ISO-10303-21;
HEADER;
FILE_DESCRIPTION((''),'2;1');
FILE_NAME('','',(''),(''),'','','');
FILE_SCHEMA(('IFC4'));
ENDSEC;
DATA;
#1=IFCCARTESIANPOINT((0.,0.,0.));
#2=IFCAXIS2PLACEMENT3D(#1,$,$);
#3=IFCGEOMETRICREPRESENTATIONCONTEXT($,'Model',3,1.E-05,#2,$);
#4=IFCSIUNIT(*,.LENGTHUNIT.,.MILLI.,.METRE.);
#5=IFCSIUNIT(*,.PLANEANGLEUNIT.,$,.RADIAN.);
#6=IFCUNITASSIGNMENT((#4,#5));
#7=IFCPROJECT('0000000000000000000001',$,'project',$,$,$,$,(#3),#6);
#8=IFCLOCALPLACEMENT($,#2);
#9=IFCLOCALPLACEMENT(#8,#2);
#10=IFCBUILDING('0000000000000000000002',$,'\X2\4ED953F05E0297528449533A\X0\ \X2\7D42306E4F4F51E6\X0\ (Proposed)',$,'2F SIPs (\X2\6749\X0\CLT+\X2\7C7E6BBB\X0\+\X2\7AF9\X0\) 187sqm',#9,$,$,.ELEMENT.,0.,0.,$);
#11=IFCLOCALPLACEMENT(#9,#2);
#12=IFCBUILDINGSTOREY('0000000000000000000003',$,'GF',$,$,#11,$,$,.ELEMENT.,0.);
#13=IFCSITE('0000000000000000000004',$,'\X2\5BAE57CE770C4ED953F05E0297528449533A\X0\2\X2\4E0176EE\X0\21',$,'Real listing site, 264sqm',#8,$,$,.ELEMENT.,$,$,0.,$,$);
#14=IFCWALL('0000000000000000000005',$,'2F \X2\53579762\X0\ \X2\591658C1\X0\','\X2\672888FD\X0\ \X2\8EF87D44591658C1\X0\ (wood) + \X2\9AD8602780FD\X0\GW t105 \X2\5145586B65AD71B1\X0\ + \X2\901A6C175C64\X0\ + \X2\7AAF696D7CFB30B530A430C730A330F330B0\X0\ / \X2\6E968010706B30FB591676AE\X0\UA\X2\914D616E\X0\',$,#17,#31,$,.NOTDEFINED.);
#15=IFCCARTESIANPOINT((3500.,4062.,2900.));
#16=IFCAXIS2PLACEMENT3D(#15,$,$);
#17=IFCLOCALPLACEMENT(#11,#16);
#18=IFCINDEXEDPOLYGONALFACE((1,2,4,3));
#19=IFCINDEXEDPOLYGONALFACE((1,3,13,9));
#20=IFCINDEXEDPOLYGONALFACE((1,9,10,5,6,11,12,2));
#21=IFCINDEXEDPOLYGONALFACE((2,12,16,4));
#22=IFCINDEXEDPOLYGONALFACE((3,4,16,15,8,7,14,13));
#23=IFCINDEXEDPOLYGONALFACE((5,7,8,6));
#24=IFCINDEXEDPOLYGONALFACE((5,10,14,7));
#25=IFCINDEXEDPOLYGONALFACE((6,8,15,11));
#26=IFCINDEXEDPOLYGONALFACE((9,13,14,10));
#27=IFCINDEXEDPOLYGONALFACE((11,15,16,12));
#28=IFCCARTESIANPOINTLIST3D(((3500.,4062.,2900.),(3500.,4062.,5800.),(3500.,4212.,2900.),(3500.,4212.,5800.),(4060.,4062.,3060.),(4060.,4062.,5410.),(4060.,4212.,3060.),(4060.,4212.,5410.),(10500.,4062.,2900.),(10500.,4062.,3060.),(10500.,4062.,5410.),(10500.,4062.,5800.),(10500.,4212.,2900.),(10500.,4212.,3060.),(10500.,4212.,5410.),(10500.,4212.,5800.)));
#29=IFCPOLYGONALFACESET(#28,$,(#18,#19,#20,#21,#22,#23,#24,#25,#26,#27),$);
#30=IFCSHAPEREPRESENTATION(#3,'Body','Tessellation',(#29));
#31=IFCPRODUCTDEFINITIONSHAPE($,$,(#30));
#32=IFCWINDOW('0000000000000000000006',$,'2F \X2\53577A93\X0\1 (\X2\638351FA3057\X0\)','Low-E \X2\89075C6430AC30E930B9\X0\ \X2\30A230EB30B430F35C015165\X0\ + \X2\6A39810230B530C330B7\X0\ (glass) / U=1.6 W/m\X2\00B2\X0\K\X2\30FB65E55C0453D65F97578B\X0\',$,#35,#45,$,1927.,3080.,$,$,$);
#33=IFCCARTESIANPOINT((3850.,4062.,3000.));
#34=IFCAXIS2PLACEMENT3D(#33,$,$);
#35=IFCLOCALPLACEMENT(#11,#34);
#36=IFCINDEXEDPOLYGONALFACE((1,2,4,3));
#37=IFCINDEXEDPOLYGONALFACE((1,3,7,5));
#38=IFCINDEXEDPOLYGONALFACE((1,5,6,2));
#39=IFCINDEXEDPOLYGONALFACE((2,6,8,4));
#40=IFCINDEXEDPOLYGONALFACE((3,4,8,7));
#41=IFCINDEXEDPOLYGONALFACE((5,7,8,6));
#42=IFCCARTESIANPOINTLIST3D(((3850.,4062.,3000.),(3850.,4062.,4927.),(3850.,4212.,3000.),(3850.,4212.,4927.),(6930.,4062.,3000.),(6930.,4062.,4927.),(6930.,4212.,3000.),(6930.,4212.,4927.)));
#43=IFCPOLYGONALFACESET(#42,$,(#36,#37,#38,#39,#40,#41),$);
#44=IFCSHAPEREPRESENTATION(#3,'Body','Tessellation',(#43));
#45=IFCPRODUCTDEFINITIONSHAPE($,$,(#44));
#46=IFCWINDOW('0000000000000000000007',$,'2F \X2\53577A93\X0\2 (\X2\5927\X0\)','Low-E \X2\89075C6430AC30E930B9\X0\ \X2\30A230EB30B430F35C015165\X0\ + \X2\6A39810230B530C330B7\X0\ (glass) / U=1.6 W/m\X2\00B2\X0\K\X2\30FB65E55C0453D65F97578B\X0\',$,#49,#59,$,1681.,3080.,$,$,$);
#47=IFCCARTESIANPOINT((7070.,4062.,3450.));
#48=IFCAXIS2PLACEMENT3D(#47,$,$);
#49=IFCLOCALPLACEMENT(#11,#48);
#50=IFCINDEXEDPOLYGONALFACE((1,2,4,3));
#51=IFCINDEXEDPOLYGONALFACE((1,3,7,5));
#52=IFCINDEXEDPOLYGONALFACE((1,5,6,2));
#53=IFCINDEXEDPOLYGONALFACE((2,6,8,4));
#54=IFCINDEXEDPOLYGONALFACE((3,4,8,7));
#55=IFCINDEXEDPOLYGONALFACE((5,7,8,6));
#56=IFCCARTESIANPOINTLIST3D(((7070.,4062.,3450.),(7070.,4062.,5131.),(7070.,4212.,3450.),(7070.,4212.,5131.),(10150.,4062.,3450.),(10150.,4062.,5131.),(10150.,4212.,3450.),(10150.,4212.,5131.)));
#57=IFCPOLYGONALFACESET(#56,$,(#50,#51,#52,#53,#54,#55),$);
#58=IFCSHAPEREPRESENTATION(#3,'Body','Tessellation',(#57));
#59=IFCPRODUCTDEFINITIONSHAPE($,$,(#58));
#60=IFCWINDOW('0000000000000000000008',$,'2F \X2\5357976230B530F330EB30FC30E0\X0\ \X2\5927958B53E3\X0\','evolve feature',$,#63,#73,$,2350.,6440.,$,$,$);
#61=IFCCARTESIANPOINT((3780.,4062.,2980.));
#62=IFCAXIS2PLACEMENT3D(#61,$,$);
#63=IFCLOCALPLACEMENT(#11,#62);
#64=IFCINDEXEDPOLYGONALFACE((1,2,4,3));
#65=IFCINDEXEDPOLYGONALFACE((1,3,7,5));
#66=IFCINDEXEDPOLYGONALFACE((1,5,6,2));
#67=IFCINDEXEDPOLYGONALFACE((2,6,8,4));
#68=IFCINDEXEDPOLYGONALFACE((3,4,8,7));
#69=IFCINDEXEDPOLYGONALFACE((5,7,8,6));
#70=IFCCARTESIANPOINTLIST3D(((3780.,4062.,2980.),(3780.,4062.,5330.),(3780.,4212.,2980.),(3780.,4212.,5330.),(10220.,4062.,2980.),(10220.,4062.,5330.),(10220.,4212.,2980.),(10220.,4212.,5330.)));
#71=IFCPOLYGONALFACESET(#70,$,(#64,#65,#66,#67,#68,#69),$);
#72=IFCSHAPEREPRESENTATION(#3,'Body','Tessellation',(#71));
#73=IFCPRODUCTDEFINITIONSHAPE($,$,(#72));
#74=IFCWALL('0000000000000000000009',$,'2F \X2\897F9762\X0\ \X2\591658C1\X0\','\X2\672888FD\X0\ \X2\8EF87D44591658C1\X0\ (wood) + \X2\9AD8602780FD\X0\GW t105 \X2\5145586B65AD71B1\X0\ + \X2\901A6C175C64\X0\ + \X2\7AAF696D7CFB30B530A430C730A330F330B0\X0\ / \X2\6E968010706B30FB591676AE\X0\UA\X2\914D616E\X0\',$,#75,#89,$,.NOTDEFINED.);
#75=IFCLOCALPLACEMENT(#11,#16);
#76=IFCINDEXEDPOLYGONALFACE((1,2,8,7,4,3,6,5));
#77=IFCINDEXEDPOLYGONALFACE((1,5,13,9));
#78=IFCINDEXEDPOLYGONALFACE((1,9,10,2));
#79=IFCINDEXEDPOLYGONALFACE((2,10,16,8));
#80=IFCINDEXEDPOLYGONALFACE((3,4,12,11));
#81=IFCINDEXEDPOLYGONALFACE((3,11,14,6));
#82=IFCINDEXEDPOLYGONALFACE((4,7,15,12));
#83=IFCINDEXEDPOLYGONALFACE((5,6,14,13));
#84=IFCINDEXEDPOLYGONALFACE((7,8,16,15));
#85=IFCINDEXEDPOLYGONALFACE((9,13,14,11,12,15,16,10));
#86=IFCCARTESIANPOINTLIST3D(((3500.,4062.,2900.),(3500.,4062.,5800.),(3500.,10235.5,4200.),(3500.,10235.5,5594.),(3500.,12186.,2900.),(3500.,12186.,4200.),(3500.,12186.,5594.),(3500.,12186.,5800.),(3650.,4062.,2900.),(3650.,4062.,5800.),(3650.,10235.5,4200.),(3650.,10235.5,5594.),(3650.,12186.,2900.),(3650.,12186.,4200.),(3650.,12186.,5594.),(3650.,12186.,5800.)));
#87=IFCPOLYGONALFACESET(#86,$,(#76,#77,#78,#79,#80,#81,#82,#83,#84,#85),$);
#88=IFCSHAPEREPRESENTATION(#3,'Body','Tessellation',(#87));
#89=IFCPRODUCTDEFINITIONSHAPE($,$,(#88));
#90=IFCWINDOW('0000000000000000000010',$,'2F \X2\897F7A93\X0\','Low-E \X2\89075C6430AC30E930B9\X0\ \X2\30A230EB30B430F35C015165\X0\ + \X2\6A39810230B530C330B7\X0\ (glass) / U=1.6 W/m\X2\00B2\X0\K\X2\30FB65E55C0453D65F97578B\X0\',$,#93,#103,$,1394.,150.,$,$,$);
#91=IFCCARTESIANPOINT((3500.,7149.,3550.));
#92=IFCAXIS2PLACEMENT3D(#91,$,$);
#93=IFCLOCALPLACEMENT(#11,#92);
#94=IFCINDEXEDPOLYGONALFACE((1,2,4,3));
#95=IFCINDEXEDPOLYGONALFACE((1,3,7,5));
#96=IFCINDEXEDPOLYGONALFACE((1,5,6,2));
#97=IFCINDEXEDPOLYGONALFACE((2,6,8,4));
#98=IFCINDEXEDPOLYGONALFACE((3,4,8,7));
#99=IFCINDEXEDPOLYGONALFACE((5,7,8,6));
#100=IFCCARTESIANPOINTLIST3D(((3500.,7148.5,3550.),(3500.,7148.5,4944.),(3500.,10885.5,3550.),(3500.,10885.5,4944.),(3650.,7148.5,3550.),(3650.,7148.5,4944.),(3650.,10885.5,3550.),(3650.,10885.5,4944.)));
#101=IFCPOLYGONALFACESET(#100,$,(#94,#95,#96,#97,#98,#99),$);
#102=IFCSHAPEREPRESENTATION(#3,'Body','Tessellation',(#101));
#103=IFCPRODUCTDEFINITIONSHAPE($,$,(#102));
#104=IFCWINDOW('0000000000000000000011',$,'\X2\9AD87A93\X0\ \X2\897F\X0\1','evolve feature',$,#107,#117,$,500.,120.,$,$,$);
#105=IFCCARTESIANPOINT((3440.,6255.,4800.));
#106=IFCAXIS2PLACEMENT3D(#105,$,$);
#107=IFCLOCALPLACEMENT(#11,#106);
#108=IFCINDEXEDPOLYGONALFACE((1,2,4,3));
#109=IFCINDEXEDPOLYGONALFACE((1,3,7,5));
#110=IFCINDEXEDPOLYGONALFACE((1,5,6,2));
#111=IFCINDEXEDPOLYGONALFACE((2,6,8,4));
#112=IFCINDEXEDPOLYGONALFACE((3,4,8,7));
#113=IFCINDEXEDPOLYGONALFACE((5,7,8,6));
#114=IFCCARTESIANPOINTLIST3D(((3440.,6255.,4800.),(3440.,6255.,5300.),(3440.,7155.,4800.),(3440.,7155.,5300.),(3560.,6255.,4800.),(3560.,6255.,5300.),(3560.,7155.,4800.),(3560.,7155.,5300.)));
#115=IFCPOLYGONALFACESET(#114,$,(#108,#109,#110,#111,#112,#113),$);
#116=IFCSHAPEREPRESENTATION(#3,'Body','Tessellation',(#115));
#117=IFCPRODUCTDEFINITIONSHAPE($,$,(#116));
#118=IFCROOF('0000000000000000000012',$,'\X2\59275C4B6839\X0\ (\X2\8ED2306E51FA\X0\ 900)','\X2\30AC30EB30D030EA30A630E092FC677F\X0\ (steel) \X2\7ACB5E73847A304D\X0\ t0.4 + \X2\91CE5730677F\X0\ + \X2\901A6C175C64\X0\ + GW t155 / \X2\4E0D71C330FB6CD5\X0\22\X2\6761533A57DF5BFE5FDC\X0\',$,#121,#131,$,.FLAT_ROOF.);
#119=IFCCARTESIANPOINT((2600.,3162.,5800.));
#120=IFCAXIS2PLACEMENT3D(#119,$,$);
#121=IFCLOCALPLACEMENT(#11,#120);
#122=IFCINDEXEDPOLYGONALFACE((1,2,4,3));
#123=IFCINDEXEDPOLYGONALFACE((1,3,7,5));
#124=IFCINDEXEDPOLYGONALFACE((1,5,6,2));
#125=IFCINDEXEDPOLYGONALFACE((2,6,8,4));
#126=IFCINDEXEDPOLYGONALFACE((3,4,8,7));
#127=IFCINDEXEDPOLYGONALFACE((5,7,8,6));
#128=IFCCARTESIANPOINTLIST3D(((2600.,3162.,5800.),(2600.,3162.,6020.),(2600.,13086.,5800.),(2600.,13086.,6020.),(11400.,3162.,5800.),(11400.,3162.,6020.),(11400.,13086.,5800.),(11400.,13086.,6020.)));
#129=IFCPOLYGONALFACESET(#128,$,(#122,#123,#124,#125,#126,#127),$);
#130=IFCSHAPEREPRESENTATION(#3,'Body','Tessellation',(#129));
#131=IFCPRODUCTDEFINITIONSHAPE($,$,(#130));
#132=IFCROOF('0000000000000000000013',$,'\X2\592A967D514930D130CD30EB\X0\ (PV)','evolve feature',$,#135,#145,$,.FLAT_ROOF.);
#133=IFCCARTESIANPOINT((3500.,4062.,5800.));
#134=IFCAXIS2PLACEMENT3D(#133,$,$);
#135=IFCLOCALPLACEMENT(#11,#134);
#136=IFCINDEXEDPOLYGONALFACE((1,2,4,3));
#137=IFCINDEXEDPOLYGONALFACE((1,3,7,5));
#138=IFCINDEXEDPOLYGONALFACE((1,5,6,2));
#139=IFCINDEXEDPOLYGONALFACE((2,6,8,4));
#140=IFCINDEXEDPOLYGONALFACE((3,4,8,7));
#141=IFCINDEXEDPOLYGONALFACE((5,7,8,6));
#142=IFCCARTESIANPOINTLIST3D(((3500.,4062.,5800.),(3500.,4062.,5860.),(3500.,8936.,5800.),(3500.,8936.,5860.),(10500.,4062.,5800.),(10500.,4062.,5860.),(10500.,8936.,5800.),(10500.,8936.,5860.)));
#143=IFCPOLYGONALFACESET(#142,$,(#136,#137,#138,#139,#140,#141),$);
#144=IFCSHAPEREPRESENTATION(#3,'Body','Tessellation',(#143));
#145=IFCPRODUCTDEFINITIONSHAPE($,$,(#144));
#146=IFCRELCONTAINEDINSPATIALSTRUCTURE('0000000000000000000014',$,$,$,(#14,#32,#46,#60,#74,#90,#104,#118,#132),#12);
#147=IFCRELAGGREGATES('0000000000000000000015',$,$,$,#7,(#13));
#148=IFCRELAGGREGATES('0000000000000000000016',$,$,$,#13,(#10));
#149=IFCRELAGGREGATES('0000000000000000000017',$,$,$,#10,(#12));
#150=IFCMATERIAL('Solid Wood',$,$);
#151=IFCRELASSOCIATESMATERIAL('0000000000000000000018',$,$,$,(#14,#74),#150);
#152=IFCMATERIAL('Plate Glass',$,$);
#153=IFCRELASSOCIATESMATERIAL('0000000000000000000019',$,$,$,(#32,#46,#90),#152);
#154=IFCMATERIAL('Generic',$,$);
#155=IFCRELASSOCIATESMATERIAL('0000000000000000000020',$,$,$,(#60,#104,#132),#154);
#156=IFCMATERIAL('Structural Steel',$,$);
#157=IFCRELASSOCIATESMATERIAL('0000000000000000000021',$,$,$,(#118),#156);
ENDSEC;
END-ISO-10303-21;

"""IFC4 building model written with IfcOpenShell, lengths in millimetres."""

from ifc_helpers import new_model, si_unit, frame, frame_2d, origin, place, context, project, spatial, rectangle, extrude, material, element, fill, save


model = new_model("IFC4")

# Units and contexts
model_context = context("Model", 3, precision=1e-05, world=origin())
ifc_project = project(units=[si_unit("LENGTHUNIT", "METRE", prefix="MILLI"), si_unit("PLANEANGLEUNIT", "RADIAN")], contexts=[model_context])

# Site, building, storey
site_placement = place(None, origin())
site = spatial("IfcSite", under=ifc_project, at=site_placement, Name="宮城県仙台市青葉区2丁目21", ObjectType="Real listing site, 264sqm", CompositionType="ELEMENT", RefElevation=0.0)
building_placement = place(site_placement, origin())
building = spatial("IfcBuilding", under=site, at=building_placement, Name="仙台市青葉区 終の住処 (Proposed)", ObjectType="2F SIPs (杉CLT+籾殻+竹) 187sqm", CompositionType="ELEMENT", ElevationOfRefHeight=0.0, ElevationOfTerrain=0.0)
storey_placement = place(building_placement, origin())
storey = spatial("IfcBuildingStorey", under=building, at=storey_placement, Name="GF", CompositionType="ELEMENT", Elevation=0.0)

# Shared definitions
ifc_material_1 = material(Name="Solid Wood")
ifc_material_2 = material(Name="Generic")

# Shared definitions
ifc_material_3 = material(Name="Plate Glass")

# Walls, openings, windows
wall_1_placement = place(storey_placement, frame((3500.0, 4062.0, 2900.0)))
wall_1 = element("IfcWall", 1, at=wall_1_placement, inside=storey, material=ifc_material_1, Name="2F 南面 外壁", Description="木製 軸組外壁 (wood) + 高性能GW t105 充填断熱 + 通気層 + 窯業系サイディング / 準耐火・外皮UA配慮", PredefinedType="NOTDEFINED", context=model_context, shape_type="SweptSolid", body=[
    extrude(rectangle(XDim=7000.0, YDim=150.0, at=frame_2d((3500.0, 75.0))), frame((3500.0, 4062.0, 2900.0)), (0.0, 0.0, 1.0), 2900.0),
])
opening_1_placement = place(storey_placement, frame((3850.0, 4062.0, 3000.0)))
opening_1 = element("IfcOpeningElement", 2, at=opening_1_placement, cuts=wall_1, PredefinedType="NOTDEFINED", context=model_context, shape_type="SweptSolid", body=[
    extrude(rectangle(XDim=3080.0, YDim=150.0, at=frame_2d((1540.0, 75.0))), frame((3850.0, 4062.0, 3000.0)), (0.0, 0.0, 1.0), 1927.0),
])
opening_2_placement = place(storey_placement, frame((7070.0, 4062.0, 3450.0)))
opening_2 = element("IfcOpeningElement", 3, at=opening_2_placement, cuts=wall_1, PredefinedType="NOTDEFINED", context=model_context, shape_type="SweptSolid", body=[
    extrude(rectangle(XDim=3080.0, YDim=150.0, at=frame_2d((1540.0, 75.0))), frame((7070.0, 4062.0, 3450.0)), (0.0, 0.0, 1.0), 1681.0),
])
opening_3_placement = place(storey_placement, frame((3780.0, 4062.0, 2980.0)))
opening_3 = element("IfcOpeningElement", 4, at=opening_3_placement, cuts=wall_1, PredefinedType="NOTDEFINED", context=model_context, shape_type="SweptSolid", body=[
    extrude(rectangle(XDim=6440.0, YDim=150.0, at=frame_2d((3220.0, 75.0))), frame((3780.0, 4062.0, 2980.0)), (0.0, 0.0, 1.0), 2350.0),
])
window_1_placement = place(storey_placement, frame((3850.0, 4062.0, 3000.0)))
window_1 = element("IfcWindow", 5, at=window_1_placement, inside=storey, material=ifc_material_3, Name="2F 南窓1 (掃出し)", Description="Low-E 複層ガラス アルゴン封入 + 樹脂サッシ (glass) / U=1.6 W/m²K・日射取得型", OverallHeight=1927.0, OverallWidth=3080.0, context=model_context, shape_type="SweptSolid", body=[
    extrude(rectangle(XDim=3080.0, YDim=150.0, at=frame_2d((1540.0, 75.0))), frame((3850.0, 4062.0, 3000.0)), (0.0, 0.0, 1.0), 1927.0),
])
fill(opening_1, window_1)
window_2_placement = place(storey_placement, frame((7070.0, 4062.0, 3450.0)))
window_2 = element("IfcWindow", 6, at=window_2_placement, inside=storey, material=ifc_material_3, Name="2F 南窓2 (大)", Description="Low-E 複層ガラス アルゴン封入 + 樹脂サッシ (glass) / U=1.6 W/m²K・日射取得型", OverallHeight=1681.0, OverallWidth=3080.0, context=model_context, shape_type="SweptSolid", body=[
    extrude(rectangle(XDim=3080.0, YDim=150.0, at=frame_2d((1540.0, 75.0))), frame((7070.0, 4062.0, 3450.0)), (0.0, 0.0, 1.0), 1681.0),
])
fill(opening_2, window_2)
window_3_placement = place(storey_placement, frame((3780.0, 4062.0, 2980.0)))
window_3 = element("IfcWindow", 7, at=window_3_placement, inside=storey, material=ifc_material_2, Name="2F 南面サンルーム 大開口", Description="evolve feature", OverallHeight=2350.0, OverallWidth=6440.0, context=model_context, shape_type="SweptSolid", body=[
    extrude(rectangle(XDim=6440.0, YDim=150.0, at=frame_2d((3220.0, 75.0))), frame((3780.0, 4062.0, 2980.0)), (0.0, 0.0, 1.0), 2350.0),
])
fill(opening_3, window_3)
wall_2_placement = place(storey_placement, frame((3500.0, 4062.0, 2900.0)))
wall_2 = element("IfcWall", 8, at=wall_2_placement, inside=storey, material=ifc_material_1, Name="2F 西面 外壁", Description="木製 軸組外壁 (wood) + 高性能GW t105 充填断熱 + 通気層 + 窯業系サイディング / 準耐火・外皮UA配慮", PredefinedType="NOTDEFINED", context=model_context, shape_type="SweptSolid", body=[
    extrude(rectangle(XDim=150.0, YDim=8124.0, at=frame_2d((75.0, 4062.0))), frame((3500.0, 4062.0, 2900.0)), (0.0, 0.0, 1.0), 2900.0),
])
opening_4_placement = place(storey_placement, frame((3500.0, 7149.0, 3550.0)))
opening_4 = element("IfcOpeningElement", 9, at=opening_4_placement, cuts=wall_2, PredefinedType="NOTDEFINED", context=model_context, shape_type="SweptSolid", body=[
    extrude(rectangle(XDim=150.0, YDim=3737.0, at=frame_2d((75.0, 1868.0))), frame((3500.0, 7149.0, 3550.0)), (0.0, 0.0, 1.0), 1394.0),
])
opening_5_placement = place(storey_placement, frame((3440.0, 6255.0, 4800.0)))
opening_5 = element("IfcOpeningElement", 10, at=opening_5_placement, cuts=wall_2, PredefinedType="NOTDEFINED", context=model_context, shape_type="SweptSolid", body=[
    extrude(rectangle(XDim=120.0, YDim=900.0, at=frame_2d((60.0, 450.0))), frame((3440.0, 6255.0, 4800.0)), (0.0, 0.0, 1.0), 500.0),
])
window_4_placement = place(storey_placement, frame((3500.0, 7149.0, 3550.0)))
window_4 = element("IfcWindow", 11, at=window_4_placement, inside=storey, material=ifc_material_3, Name="2F 西窓", Description="Low-E 複層ガラス アルゴン封入 + 樹脂サッシ (glass) / U=1.6 W/m²K・日射取得型", OverallHeight=1394.0, OverallWidth=150.0, context=model_context, shape_type="SweptSolid", body=[
    extrude(rectangle(XDim=150.0, YDim=3737.0, at=frame_2d((75.0, 1868.0))), frame((3500.0, 7149.0, 3550.0)), (0.0, 0.0, 1.0), 1394.0),
])
fill(opening_4, window_4)
window_5_placement = place(storey_placement, frame((3440.0, 6255.0, 4800.0)))
window_5 = element("IfcWindow", 12, at=window_5_placement, inside=storey, material=ifc_material_2, Name="高窓 西1", Description="evolve feature", OverallHeight=500.0, OverallWidth=120.0, context=model_context, shape_type="SweptSolid", body=[
    extrude(rectangle(XDim=120.0, YDim=900.0, at=frame_2d((60.0, 450.0))), frame((3440.0, 6255.0, 4800.0)), (0.0, 0.0, 1.0), 500.0),
])
fill(opening_5, window_5)

# Roofs
ifc_material_4 = material(Name="Structural Steel")
roof_1_placement = place(storey_placement, frame((2600.0, 3162.0, 5800.0)))
element("IfcRoof", 13, at=roof_1_placement, inside=storey, material=ifc_material_4, Name="大屋根 (軒の出 900)", Description="ガルバリウム鋼板 (steel) 立平葺き t0.4 + 野地板 + 通気層 + GW t155 / 不燃・法22条区域対応", PredefinedType="FLAT_ROOF", context=model_context, shape_type="SweptSolid", body=[
    extrude(rectangle(XDim=8800.0, YDim=9924.0, at=frame_2d((4400.0, 4962.0))), frame((2600.0, 3162.0, 5800.0)), (0.0, 0.0, 1.0), 220.0),
])
roof_2_placement = place(storey_placement, frame((3500.0, 4062.0, 5800.0)))
element("IfcRoof", 14, at=roof_2_placement, inside=storey, material=ifc_material_2, Name="太陽光パネル (PV)", Description="evolve feature", PredefinedType="FLAT_ROOF", context=model_context, shape_type="SweptSolid", body=[
    extrude(rectangle(XDim=7000.0, YDim=4874.0, at=frame_2d((3500.0, 2437.0))), frame((3500.0, 4062.0, 5800.0)), (0.0, 0.0, 1.0), 60.0),
])

save(model, "model.ifc")
